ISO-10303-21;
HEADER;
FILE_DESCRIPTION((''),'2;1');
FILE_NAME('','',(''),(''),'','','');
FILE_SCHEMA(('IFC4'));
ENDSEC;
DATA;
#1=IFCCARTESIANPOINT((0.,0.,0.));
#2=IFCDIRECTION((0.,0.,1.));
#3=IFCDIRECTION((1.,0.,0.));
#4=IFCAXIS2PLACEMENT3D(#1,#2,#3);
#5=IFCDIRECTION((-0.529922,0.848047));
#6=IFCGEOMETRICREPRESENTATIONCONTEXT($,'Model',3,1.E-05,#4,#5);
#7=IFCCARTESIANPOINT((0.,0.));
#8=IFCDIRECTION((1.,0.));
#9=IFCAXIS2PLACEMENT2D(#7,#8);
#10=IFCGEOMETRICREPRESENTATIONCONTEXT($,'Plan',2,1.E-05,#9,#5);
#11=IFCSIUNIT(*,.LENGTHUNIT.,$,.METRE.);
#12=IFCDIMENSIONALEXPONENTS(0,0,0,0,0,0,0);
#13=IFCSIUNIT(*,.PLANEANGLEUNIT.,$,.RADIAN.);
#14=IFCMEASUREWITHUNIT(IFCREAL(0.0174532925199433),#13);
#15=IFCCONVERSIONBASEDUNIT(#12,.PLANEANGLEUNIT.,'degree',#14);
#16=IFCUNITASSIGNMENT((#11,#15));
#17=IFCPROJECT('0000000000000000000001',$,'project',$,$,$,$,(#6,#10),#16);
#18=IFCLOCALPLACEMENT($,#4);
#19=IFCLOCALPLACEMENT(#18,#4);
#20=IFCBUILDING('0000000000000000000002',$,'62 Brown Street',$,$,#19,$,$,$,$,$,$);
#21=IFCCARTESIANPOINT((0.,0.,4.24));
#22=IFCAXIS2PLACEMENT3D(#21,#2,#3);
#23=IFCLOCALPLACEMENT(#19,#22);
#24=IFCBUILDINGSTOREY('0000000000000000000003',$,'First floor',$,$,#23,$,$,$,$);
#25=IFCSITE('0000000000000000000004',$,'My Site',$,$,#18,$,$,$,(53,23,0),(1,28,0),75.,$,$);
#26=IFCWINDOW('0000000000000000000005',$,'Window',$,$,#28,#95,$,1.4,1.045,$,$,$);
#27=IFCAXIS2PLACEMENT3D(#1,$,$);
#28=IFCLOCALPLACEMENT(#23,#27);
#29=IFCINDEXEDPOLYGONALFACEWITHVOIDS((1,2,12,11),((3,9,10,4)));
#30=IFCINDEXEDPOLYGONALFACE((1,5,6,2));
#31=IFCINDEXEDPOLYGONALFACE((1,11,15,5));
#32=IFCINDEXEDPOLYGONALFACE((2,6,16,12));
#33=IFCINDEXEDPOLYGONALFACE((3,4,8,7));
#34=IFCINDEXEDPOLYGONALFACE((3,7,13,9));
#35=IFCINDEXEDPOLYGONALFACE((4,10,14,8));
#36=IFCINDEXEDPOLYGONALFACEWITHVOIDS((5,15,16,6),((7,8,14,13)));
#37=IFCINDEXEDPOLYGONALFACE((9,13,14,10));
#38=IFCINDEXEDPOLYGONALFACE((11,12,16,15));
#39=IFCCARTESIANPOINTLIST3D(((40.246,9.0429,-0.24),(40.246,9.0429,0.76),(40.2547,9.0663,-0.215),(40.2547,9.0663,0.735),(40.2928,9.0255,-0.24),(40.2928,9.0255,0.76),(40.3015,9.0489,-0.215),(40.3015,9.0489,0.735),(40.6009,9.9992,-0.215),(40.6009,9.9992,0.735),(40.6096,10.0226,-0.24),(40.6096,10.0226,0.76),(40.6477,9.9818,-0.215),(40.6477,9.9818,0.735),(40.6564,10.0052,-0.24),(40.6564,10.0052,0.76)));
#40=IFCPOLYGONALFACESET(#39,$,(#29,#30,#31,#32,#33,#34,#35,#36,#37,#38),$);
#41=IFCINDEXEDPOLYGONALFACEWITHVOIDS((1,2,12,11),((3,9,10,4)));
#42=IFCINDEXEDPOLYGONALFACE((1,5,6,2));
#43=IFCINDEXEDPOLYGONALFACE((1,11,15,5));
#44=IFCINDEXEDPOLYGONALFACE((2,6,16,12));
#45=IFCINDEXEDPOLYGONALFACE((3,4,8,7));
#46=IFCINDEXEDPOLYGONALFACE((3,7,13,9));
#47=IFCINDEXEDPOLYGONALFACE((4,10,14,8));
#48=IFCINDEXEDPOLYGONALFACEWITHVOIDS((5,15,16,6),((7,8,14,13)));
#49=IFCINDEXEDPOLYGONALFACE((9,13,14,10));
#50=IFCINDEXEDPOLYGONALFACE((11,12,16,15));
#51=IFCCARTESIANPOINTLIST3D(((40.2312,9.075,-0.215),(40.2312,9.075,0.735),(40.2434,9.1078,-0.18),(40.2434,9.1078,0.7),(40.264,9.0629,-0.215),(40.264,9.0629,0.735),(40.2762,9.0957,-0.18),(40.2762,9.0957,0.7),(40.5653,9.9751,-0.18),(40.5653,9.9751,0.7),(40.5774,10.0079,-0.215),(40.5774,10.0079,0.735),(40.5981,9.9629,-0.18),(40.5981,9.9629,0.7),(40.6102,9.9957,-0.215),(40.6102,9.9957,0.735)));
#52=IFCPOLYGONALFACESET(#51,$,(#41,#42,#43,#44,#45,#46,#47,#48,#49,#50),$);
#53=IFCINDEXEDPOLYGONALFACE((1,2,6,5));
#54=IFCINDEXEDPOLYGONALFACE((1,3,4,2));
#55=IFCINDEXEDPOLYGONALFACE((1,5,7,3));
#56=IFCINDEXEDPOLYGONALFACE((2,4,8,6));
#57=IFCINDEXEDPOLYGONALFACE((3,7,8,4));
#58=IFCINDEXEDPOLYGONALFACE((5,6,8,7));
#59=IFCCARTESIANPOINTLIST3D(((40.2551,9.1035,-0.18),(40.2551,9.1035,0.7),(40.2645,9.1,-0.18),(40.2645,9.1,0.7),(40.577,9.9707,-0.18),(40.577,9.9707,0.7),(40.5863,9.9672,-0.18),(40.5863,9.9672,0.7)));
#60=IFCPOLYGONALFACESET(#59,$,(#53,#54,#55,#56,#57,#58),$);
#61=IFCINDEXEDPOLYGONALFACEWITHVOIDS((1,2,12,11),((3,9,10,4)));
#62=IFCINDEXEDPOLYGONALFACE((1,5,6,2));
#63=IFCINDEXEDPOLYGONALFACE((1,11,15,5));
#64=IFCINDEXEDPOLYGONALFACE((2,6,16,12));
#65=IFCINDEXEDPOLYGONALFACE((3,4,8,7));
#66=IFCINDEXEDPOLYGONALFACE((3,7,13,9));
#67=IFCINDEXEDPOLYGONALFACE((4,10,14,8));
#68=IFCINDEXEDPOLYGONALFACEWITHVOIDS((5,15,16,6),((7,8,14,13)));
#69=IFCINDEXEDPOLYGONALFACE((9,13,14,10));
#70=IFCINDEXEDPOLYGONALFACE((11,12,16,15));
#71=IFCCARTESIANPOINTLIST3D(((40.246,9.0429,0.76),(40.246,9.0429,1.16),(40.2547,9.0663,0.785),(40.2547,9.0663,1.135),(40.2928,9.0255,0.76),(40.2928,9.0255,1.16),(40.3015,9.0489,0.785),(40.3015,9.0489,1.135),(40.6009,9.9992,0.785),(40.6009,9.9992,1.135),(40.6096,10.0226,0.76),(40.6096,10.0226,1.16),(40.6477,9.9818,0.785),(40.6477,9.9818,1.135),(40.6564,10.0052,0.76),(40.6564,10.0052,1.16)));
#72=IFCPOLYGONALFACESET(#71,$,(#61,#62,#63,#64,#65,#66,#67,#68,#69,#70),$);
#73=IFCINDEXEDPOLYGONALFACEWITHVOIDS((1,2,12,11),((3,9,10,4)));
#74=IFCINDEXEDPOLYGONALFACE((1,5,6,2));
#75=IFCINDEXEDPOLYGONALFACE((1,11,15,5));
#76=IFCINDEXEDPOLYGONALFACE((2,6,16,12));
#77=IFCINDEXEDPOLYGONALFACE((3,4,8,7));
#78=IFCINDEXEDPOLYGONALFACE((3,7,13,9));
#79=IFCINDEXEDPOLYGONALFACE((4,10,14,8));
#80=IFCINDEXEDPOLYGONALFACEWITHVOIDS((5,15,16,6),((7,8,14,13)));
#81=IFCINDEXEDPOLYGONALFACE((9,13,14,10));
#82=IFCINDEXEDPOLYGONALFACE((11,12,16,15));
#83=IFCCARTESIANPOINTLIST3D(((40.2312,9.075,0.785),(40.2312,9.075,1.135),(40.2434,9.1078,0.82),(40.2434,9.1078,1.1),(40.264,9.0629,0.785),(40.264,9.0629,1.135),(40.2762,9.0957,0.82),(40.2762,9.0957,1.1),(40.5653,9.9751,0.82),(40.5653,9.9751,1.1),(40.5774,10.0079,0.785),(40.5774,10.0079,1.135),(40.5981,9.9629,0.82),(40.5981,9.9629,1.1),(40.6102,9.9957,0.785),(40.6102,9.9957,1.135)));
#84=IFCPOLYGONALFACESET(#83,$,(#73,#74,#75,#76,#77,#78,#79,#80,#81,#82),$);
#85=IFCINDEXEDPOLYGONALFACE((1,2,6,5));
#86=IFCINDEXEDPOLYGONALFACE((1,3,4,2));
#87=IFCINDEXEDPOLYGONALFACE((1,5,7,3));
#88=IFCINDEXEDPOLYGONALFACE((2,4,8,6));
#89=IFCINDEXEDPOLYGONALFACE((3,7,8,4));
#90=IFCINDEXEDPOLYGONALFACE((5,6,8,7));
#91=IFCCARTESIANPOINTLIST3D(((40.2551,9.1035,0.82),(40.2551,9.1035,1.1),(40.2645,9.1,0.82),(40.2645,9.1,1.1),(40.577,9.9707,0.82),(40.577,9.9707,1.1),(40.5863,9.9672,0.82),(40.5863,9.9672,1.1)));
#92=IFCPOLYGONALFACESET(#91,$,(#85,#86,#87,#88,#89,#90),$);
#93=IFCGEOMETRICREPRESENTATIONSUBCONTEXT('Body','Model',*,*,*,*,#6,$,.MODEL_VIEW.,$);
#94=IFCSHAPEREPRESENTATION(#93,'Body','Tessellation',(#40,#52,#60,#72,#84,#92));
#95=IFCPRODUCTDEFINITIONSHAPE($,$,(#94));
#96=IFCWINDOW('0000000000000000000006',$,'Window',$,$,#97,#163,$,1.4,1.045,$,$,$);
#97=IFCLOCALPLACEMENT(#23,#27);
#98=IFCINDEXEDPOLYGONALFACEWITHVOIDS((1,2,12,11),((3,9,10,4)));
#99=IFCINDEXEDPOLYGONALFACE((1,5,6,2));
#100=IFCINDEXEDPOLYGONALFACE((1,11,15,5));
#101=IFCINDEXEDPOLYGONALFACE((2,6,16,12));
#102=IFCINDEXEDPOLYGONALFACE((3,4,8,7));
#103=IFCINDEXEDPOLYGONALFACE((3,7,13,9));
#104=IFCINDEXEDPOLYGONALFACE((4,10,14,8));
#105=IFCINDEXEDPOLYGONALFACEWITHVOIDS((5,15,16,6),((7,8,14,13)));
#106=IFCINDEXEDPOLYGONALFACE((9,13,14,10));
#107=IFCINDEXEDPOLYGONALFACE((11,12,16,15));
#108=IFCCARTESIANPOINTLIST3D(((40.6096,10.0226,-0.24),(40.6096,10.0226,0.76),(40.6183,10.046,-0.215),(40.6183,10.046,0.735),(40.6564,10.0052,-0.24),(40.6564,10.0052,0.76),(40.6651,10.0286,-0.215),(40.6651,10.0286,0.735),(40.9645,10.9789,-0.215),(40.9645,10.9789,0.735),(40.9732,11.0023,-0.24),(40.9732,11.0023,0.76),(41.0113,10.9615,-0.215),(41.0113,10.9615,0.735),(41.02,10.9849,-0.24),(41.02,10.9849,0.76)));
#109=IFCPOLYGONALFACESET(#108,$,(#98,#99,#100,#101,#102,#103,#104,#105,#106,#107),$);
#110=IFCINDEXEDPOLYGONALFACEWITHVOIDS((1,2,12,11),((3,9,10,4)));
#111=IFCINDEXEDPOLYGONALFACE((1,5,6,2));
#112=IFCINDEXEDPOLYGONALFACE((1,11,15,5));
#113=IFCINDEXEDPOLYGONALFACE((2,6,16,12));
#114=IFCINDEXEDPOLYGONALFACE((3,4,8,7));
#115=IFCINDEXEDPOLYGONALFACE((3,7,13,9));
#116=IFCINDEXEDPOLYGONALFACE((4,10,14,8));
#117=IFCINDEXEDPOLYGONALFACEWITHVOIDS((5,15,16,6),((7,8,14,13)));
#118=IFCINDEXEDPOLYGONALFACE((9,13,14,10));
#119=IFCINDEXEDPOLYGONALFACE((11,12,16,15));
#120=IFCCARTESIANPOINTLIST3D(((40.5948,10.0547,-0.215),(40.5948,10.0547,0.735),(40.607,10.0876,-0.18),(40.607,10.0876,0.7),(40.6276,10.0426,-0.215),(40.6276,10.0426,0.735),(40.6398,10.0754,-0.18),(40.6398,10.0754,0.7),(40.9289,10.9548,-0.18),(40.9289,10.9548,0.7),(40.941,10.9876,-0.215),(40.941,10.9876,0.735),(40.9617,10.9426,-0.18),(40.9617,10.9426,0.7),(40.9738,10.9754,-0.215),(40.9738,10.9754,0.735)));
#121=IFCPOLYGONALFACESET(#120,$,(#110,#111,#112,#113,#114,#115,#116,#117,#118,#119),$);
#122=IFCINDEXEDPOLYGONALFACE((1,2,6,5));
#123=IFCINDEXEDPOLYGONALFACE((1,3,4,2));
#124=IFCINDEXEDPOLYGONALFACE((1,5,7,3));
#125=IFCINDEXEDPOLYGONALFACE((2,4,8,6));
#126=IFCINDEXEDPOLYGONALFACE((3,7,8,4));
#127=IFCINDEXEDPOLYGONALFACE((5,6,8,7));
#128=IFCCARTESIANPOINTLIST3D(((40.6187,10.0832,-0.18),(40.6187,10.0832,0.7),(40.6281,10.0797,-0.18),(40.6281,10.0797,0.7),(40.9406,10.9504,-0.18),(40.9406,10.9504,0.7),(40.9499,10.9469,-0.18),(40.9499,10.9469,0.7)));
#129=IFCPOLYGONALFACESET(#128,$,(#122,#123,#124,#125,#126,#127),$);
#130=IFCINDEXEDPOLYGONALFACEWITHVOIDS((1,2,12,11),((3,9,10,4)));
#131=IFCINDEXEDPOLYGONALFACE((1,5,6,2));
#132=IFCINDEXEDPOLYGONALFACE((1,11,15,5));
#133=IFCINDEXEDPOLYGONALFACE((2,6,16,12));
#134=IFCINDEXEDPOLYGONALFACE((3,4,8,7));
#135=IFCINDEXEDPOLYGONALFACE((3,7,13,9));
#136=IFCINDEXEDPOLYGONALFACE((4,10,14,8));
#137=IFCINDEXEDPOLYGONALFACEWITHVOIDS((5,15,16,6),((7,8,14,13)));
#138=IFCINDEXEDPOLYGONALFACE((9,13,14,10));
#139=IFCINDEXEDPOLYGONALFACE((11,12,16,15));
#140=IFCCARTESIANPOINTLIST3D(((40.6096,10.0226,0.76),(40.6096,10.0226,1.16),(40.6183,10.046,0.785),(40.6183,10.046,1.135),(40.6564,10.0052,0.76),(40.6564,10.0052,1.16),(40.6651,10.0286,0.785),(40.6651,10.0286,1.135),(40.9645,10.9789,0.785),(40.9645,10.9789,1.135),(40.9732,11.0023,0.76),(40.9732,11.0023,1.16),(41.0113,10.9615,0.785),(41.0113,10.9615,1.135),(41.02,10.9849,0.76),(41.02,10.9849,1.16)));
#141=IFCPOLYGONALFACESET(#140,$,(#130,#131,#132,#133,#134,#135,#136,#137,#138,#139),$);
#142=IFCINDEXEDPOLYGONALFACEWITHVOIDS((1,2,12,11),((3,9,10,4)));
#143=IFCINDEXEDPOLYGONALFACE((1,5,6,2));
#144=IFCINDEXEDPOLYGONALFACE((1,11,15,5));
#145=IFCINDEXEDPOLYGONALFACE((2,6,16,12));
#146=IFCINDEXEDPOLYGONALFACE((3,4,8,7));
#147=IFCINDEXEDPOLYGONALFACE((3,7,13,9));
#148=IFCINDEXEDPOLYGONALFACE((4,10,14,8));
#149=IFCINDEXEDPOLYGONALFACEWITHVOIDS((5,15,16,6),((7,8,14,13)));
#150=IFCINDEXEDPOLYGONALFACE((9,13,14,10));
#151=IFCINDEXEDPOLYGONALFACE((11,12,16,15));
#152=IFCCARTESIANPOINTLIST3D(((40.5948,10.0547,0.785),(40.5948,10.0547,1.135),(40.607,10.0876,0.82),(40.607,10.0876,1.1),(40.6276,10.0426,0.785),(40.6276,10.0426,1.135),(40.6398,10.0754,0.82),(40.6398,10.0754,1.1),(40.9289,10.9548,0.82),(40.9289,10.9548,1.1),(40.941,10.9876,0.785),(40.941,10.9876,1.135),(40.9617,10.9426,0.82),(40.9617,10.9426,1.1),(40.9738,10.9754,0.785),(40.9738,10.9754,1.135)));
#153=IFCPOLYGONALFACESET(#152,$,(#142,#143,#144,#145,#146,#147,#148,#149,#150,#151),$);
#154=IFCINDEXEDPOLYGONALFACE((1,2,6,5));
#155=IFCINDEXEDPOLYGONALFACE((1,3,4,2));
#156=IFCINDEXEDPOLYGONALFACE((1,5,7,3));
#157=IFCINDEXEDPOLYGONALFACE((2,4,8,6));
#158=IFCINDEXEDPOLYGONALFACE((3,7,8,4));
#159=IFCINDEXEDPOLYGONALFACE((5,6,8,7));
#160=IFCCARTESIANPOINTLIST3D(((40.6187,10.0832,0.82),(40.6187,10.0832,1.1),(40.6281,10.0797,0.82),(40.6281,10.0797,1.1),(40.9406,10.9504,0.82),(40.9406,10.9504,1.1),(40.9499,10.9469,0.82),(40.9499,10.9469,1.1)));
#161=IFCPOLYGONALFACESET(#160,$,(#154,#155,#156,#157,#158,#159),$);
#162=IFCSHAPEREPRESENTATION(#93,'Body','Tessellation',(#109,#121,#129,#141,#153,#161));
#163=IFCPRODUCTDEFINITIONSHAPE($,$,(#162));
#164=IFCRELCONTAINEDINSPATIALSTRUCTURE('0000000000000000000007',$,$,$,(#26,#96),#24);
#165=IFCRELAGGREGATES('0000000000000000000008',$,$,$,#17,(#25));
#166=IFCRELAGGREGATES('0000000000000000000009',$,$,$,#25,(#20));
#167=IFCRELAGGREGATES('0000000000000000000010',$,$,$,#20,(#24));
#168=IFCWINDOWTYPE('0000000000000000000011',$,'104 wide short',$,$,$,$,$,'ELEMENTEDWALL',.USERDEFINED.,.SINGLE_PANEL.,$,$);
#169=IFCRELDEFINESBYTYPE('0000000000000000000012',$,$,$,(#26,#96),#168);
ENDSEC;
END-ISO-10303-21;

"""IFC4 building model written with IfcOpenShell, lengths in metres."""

from ifc_helpers import new_model, entity, si_unit, converted_unit, direction, frame, origin_with_axes, origin_2d_with_axis, place, context, subcontext, project, spatial, line, indexed_curve, outline, extrude, shape, source, transform, mapped, type_object, type_shapes, element, save


model = new_model("IFC4")

# Units and contexts
model_context = context("Model", 3, precision=1e-05, world=origin_with_axes(), true_north=direction((-0.529922, 0.848047)))
plan_context = context("Plan", 2, precision=1e-05, world=origin_2d_with_axis(), true_north=direction((-0.529922, 0.848047)))
body_context_1 = subcontext(model_context, "Body", "Model", "MODEL_VIEW")
body_context_2 = subcontext(plan_context, "Body", "Plan", "PLAN_VIEW")
ifc_project = project(units=[si_unit("LENGTHUNIT", "METRE"), converted_unit("PLANEANGLEUNIT", "degree", entity("IfcReal", 0.0174532925199433), si_unit("PLANEANGLEUNIT", "RADIAN"), dimensions=[0, 0, 0, 0, 0, 0, 0])], contexts=[model_context, plan_context])

# Site, building, storey
site_placement = place(None, origin_with_axes())
site = spatial("IfcSite", under=ifc_project, at=site_placement, Name="My Site", RefLatitude=(53, 23, 0), RefLongitude=(1, 28, 0), RefElevation=75.0)
building_placement = place(site_placement, origin_with_axes())
building = spatial("IfcBuilding", under=site, at=building_placement, Name="62 Brown Street")
storey_placement = place(building_placement, frame((0.0, 0.0, 4.24), z_axis=(0.0, 0.0, 1.0), x_axis=(1.0, 0.0, 0.0)))
storey = spatial("IfcBuildingStorey", under=building, at=storey_placement, Name="First floor")

# Shared definitions
window_type = type_object("IfcWindowType", Name="104 wide short", ElementType="ELEMENTEDWALL", PartitioningType="SINGLE_PANEL", PredefinedType="USERDEFINED")
shared_shape_1 = source(origin_with_axes(), body_context_1, "Body", "SweptSolid", [
    extrude(outline(indexed_curve([(0.0, 0.0), (1.045, 0.0), (1.045, 1.0), (0.0, 1.0)], segments=[line(1, 2, 3, 4, 1)]), holes=[indexed_curve([(0.025, 0.025), (1.02, 0.025), (1.02, 0.975), (0.025, 0.975)], segments=[line(1, 2, 3, 4, 1)])]), frame((0.0, 0.15, 0.0), z_axis=(0.0, -1.0, 0.0), x_axis=(1.0, 0.0, 0.0)), (0.0, 0.0, -1.0), 0.05),
    extrude(outline(indexed_curve([(0.0, 0.0), (0.995, 0.0), (0.995, 0.95), (0.0, 0.95)], segments=[line(1, 2, 3, 4, 1)]), holes=[indexed_curve([(0.035, 0.035), (0.96, 0.035), (0.96, 0.915), (0.035, 0.915)], segments=[line(1, 2, 3, 4, 1)])]), frame((0.025, 0.19, 0.025), z_axis=(0.0, -1.0, 0.0), x_axis=(1.0, 0.0, 0.0)), (0.0, 0.0, -1.0), 0.035),
    extrude(outline(indexed_curve([(0.035, 0.035), (0.96, 0.035), (0.96, 0.915), (0.035, 0.915)], segments=[line(1, 2, 3, 4, 1)])), frame((0.025, 0.2025, 0.025), z_axis=(0.0, -1.0, 0.0), x_axis=(1.0, 0.0, 0.0)), (0.0, 0.0, -1.0), 0.01),
    extrude(outline(indexed_curve([(0.0, 0.0), (1.045, 0.0), (1.045, 0.4), (0.0, 0.4)], segments=[line(1, 2, 3, 4, 1)]), holes=[indexed_curve([(0.025, 0.025), (1.02, 0.025), (1.02, 0.375), (0.025, 0.375)], segments=[line(1, 2, 3, 4, 1)])]), frame((0.0, 0.15, 1.0), z_axis=(0.0, -1.0, 0.0), x_axis=(1.0, 0.0, 0.0)), (0.0, 0.0, -1.0), 0.05),
    extrude(outline(indexed_curve([(0.0, 0.0), (0.995, 0.0), (0.995, 0.35), (0.0, 0.35)], segments=[line(1, 2, 3, 4, 1)]), holes=[indexed_curve([(0.035, 0.035), (0.96, 0.035), (0.96, 0.315), (0.035, 0.315)], segments=[line(1, 2, 3, 4, 1)])]), frame((0.025, 0.19, 1.025), z_axis=(0.0, -1.0, 0.0), x_axis=(1.0, 0.0, 0.0)), (0.0, 0.0, -1.0), 0.035),
    extrude(outline(indexed_curve([(0.035, 0.035), (0.96, 0.035), (0.96, 0.315), (0.035, 0.315)], segments=[line(1, 2, 3, 4, 1)])), frame((0.025, 0.2025, 1.025), z_axis=(0.0, -1.0, 0.0), x_axis=(1.0, 0.0, 0.0)), (0.0, 0.0, -1.0), 0.01),
])
shared_shape_2 = source(origin_with_axes(), body_context_2, "Body", "Curve2D", [
    entity("IfcIndexedPolyCurve", entity("IfcCartesianPointList2D", [[0.025, 0.15], [1.02, 0.15]])),
    entity("IfcIndexedPolyCurve", entity("IfcCartesianPointList2D", [[0.0, 0.2], [0.025, 0.2], [0.025, 0.15], [0.0, 0.15]]), [entity("IfcLineIndex", [1, 2, 3, 4, 1])]),
    entity("IfcIndexedPolyCurve", entity("IfcCartesianPointList2D", [[1.045, 0.2], [1.02, 0.2], [1.02, 0.15], [1.045, 0.15]]), [entity("IfcLineIndex", [1, 2, 3, 4, 1])]),
    entity("IfcIndexedPolyCurve", entity("IfcCartesianPointList2D", [[0.025, 0.19], [0.06, 0.19], [0.06, 0.225], [0.025, 0.225]]), [entity("IfcLineIndex", [1, 2, 3, 4, 1])]),
    entity("IfcIndexedPolyCurve", entity("IfcCartesianPointList2D", [[1.02, 0.19], [0.985, 0.19], [0.985, 0.225], [1.02, 0.225]]), [entity("IfcLineIndex", [1, 2, 3, 4, 1])]),
    entity("IfcIndexedPolyCurve", entity("IfcCartesianPointList2D", [[0.06, 0.19], [0.985, 0.19]])),
    entity("IfcIndexedPolyCurve", entity("IfcCartesianPointList2D", [[0.06, 0.225], [0.985, 0.225]])),
    entity("IfcIndexedPolyCurve", entity("IfcCartesianPointList2D", [[0.06, 0.2075], [0.985, 0.2075]])),
])
type_shapes(window_type, [shared_shape_1, shared_shape_2])

# Windows
for number, where, z_axis, x_axis, name in (
    (1, (40.4335, 8.9733, -0.24), (0.0, 0.0, 1.0), (0.347944, 0.937515, 0.0), "Window"),
    (2, (40.7971, 9.953, -0.24), (0.0, 0.0, 1.0), (0.347944, 0.937515, 0.0), "Window"),
):
    element("IfcWindow", number, at=place(storey_placement, frame(where, z_axis=z_axis, x_axis=x_axis)), inside=storey, type_object=window_type, Name=name, OverallHeight=1.4, OverallWidth=1.045, shapes=[
        shape(body_context_1, "Body", "MappedRepresentation", [mapped(shared_shape_1, transform((0.0, 0.0, 0.0), x_axis=(1.0, 0.0, 0.0), y_axis=(0.0, 1.0, 0.0), z_axis=(0.0, 0.0, 1.0), scale=1.0))]),
        shape(body_context_2, "Body", "MappedRepresentation", [mapped(shared_shape_2, transform((0.0, 0.0, 0.0), x_axis=(1.0, 0.0, 0.0), y_axis=(0.0, 1.0, 0.0), z_axis=(0.0, 0.0, 1.0), scale=1.0))]),
    ])

save(model, "model.ifc")
